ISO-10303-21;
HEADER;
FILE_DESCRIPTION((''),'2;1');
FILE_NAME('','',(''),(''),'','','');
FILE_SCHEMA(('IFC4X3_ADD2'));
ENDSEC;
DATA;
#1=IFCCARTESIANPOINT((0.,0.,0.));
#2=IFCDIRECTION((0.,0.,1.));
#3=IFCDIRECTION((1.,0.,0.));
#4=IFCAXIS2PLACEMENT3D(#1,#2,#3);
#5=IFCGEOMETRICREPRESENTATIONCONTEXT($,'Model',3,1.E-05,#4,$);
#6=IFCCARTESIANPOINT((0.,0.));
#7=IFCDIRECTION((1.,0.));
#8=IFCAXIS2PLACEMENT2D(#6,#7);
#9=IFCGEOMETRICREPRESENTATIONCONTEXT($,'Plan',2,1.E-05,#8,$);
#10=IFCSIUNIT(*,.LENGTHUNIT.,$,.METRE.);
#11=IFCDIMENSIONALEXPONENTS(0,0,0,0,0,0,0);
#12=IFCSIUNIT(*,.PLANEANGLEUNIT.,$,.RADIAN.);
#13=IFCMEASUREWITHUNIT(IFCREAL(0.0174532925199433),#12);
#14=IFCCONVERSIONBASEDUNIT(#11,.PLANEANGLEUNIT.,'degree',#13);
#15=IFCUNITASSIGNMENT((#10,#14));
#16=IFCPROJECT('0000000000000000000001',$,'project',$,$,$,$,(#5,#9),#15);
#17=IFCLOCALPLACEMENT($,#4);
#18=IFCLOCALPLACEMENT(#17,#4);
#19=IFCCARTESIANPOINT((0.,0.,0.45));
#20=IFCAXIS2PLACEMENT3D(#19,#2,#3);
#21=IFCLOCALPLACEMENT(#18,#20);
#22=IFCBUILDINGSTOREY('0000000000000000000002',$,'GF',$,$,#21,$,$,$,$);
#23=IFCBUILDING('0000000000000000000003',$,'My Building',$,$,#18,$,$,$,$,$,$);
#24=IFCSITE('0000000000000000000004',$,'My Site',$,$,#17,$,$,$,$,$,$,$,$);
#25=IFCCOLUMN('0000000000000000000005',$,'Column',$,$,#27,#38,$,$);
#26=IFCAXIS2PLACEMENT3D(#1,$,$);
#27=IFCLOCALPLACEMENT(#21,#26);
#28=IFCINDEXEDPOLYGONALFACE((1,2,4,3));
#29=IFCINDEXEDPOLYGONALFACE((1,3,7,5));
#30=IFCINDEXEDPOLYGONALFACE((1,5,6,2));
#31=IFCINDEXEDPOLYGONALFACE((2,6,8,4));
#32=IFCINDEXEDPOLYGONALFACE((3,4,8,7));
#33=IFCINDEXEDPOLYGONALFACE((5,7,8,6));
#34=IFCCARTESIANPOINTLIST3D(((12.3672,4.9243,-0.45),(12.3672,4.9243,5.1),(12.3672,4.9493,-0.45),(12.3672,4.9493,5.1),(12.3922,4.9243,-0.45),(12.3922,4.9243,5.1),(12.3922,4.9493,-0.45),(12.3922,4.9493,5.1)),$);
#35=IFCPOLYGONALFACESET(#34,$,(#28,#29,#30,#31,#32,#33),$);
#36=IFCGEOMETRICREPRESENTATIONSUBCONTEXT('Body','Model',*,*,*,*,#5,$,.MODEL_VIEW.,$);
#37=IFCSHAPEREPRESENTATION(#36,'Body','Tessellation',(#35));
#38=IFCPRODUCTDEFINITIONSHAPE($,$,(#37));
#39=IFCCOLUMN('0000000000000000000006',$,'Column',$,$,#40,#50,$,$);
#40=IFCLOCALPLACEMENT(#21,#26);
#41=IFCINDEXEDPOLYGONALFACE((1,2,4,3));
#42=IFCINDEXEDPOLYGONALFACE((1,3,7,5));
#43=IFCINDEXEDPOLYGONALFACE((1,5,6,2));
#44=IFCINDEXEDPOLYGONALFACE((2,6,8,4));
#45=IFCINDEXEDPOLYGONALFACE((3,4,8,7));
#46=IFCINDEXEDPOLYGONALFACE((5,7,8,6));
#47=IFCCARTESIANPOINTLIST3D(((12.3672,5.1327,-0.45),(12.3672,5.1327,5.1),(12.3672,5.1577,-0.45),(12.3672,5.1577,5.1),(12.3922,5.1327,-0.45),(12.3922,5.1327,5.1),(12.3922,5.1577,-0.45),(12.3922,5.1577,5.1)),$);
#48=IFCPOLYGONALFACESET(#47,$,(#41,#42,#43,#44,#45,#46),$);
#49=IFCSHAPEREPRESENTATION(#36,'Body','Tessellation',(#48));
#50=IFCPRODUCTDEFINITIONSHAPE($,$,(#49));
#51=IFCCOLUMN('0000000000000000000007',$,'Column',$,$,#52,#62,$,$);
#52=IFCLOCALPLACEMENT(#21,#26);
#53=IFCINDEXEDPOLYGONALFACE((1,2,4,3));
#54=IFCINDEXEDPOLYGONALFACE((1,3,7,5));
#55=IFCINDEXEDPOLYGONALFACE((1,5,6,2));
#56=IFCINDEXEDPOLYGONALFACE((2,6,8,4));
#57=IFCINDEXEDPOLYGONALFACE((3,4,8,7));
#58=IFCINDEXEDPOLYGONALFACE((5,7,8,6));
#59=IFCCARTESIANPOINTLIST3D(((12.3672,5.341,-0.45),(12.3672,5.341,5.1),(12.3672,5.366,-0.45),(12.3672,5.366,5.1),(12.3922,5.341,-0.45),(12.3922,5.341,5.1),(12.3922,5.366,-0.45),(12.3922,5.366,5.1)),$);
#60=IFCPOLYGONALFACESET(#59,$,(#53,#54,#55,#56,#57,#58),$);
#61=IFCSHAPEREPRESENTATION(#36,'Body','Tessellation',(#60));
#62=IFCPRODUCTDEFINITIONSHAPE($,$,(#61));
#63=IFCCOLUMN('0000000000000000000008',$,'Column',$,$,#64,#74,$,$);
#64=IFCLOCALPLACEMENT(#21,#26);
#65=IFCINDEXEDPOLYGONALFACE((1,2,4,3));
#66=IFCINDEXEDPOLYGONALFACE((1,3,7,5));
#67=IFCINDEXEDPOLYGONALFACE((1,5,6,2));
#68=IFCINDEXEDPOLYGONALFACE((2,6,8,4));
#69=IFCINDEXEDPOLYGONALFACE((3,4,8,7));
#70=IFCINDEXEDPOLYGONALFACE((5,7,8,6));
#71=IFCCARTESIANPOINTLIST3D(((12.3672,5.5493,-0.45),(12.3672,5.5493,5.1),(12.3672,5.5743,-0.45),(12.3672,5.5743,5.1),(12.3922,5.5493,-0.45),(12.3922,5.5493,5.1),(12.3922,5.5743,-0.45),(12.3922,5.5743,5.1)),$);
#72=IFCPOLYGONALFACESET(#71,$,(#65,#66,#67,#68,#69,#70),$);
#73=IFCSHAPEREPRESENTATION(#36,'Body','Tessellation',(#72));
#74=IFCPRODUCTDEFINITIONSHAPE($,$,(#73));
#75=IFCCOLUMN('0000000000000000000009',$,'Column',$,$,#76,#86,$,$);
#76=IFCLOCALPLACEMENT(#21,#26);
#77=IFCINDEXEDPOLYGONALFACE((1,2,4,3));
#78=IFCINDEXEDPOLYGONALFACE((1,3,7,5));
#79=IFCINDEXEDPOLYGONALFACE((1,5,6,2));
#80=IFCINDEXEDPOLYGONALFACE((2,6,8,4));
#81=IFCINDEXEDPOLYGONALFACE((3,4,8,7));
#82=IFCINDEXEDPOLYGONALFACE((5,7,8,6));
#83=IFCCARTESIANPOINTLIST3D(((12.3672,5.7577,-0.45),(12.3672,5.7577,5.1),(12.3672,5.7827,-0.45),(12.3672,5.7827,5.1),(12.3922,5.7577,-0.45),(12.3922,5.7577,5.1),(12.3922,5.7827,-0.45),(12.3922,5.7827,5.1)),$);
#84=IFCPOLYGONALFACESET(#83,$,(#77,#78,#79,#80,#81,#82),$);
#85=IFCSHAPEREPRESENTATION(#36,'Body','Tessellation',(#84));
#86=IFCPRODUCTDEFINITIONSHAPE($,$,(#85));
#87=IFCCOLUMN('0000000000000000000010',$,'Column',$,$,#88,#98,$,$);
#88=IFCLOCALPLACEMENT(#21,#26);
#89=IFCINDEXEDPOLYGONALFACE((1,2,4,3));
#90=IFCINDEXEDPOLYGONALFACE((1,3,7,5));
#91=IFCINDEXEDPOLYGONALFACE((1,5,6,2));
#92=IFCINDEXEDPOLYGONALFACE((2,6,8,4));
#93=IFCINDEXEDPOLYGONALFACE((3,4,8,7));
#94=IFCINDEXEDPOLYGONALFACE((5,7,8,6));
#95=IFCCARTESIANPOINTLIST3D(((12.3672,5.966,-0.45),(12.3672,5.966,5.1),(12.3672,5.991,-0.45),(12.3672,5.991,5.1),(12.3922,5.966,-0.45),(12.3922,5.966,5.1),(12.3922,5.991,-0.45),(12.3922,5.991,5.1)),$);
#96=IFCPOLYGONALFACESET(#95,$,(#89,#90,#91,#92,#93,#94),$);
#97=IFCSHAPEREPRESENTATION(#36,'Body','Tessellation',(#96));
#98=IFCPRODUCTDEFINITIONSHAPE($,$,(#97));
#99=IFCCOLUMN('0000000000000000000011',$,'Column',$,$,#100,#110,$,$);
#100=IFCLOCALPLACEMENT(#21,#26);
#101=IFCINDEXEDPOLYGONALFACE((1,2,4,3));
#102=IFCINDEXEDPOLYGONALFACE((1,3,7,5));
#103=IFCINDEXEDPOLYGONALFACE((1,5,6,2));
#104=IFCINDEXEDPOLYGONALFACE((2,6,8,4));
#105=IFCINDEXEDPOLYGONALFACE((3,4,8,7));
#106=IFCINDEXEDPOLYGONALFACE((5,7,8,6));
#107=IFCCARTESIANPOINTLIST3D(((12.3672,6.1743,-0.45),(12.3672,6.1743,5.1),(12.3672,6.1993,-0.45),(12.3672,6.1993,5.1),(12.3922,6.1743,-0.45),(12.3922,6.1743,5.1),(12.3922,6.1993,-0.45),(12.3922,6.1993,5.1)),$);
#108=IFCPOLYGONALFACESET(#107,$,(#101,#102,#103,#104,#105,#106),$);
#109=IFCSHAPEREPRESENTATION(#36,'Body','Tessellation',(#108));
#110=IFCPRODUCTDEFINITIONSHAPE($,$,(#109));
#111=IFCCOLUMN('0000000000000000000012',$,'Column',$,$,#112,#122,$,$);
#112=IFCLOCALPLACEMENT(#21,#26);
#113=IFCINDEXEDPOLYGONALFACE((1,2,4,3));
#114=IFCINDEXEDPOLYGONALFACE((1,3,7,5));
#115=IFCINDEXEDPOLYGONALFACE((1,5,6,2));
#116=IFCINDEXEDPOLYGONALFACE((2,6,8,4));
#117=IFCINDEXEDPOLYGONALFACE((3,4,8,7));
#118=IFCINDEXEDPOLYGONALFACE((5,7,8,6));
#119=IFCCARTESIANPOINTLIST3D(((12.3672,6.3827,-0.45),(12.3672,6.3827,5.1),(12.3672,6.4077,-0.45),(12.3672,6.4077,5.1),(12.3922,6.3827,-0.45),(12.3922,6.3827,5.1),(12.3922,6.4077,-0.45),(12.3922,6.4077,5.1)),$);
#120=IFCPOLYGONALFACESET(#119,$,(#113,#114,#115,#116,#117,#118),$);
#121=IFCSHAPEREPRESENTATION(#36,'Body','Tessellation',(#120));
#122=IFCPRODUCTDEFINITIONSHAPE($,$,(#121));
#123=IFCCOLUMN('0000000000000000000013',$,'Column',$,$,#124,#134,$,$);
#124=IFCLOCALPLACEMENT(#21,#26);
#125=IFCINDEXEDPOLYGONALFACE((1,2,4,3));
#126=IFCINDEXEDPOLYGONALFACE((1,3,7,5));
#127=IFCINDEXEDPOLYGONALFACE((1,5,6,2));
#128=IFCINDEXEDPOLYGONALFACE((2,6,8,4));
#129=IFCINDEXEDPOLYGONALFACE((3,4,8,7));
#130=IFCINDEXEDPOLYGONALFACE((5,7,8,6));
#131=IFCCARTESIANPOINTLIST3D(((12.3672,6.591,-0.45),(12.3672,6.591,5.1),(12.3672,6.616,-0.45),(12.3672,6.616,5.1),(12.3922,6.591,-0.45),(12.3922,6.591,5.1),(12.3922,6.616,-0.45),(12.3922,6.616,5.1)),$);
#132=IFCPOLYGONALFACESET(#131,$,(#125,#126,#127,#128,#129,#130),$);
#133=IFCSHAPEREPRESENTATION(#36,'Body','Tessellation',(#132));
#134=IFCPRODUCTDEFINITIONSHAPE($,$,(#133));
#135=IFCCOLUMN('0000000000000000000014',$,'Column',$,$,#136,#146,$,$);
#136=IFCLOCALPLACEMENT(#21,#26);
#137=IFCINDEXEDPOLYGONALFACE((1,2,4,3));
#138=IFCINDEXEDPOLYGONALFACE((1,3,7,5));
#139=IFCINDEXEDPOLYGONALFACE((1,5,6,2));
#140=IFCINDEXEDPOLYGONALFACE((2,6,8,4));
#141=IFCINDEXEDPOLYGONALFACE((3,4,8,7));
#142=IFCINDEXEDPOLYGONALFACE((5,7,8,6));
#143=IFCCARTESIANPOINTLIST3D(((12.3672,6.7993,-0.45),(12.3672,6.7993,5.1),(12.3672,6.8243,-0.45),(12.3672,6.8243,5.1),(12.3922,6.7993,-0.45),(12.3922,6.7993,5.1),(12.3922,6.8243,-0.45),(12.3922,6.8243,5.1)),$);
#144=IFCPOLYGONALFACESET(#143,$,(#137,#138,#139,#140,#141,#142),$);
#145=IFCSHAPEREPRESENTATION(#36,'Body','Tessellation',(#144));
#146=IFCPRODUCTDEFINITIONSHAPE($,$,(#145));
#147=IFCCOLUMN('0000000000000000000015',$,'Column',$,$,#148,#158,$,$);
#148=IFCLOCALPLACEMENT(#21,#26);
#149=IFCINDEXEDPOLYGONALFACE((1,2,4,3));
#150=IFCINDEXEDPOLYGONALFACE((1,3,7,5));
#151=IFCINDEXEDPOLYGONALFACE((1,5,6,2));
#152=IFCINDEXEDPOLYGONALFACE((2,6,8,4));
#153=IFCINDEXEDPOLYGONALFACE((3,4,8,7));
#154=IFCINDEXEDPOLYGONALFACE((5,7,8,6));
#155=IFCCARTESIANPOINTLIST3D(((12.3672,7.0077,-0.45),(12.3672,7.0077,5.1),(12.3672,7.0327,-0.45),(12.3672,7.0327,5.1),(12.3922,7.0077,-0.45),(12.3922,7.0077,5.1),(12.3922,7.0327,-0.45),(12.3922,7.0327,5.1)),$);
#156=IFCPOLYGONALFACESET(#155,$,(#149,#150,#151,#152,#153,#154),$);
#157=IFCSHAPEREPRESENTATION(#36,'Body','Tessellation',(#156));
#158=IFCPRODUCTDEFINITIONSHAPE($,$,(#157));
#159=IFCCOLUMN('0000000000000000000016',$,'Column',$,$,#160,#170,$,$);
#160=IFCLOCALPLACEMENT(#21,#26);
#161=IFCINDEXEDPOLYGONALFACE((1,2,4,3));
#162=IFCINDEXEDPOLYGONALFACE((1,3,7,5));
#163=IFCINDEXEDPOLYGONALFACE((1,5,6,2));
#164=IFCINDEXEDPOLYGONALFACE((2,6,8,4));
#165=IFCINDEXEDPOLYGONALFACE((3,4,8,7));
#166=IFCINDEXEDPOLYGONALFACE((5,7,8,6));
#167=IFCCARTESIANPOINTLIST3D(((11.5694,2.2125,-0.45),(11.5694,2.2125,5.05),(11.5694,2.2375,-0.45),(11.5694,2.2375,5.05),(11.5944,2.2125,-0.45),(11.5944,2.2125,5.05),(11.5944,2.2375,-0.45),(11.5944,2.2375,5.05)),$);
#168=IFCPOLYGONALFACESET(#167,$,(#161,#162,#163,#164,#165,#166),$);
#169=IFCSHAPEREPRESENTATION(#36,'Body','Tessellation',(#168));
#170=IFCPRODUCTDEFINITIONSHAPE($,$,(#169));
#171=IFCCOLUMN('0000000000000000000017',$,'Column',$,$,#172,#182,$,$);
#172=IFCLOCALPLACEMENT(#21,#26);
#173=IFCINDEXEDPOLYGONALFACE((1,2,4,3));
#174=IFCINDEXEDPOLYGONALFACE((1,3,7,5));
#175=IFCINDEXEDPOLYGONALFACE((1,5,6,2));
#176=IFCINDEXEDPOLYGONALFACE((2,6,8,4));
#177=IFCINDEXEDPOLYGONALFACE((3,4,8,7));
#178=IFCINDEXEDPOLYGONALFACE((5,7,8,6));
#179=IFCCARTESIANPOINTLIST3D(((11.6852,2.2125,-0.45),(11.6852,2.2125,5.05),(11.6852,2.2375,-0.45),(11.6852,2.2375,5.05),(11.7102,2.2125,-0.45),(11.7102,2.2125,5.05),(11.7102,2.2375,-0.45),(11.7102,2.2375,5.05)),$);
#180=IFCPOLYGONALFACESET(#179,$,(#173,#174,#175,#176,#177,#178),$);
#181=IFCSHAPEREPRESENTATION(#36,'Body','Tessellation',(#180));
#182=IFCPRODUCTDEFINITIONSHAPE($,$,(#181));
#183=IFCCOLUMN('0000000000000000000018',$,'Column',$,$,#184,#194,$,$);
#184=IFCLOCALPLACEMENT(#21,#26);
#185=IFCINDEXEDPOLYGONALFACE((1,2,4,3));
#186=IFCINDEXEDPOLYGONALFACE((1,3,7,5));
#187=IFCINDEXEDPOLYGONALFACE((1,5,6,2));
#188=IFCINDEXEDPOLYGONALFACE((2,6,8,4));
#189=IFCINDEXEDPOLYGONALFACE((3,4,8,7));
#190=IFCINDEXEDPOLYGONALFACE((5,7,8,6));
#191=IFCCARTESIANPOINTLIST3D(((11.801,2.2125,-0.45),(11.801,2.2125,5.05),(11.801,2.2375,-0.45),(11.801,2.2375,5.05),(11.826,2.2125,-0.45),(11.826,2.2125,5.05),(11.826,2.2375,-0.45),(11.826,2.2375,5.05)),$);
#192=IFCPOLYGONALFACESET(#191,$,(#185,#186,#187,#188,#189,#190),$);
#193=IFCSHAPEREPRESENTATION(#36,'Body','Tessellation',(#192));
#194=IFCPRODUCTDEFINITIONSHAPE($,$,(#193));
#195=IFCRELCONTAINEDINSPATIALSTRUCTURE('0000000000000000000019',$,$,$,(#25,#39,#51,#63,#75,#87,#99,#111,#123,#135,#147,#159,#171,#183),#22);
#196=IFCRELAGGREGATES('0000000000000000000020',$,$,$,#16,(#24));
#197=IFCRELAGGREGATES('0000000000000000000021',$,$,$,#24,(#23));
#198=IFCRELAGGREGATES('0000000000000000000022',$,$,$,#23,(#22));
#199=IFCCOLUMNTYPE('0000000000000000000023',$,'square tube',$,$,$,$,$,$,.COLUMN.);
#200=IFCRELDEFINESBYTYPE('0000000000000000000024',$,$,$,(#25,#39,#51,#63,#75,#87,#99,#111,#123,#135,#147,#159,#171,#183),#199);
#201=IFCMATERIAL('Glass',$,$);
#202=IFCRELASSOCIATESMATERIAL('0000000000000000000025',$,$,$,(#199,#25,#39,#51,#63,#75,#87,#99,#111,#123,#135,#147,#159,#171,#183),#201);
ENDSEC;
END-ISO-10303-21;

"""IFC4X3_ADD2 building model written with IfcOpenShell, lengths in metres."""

from ifc_helpers import new_model, entity, si_unit, converted_unit, frame, origin_with_axes, origin_2d_with_axis, place, context, subcontext, project, spatial, rectangle, extrude, material, material_profile, profile_set, profile_usage, type_object, element, save


model = new_model("IFC4X3_ADD2")

# Units and contexts
model_context = context("Model", 3, precision=1e-05, world=origin_with_axes())
plan_context = context("Plan", 2, precision=1e-05, world=origin_2d_with_axis())
body_context = subcontext(model_context, "Body", "Model", "MODEL_VIEW")
ifc_project = project(units=[si_unit("LENGTHUNIT", "METRE"), converted_unit("PLANEANGLEUNIT", "degree", entity("IfcReal", 0.0174532925199433), si_unit("PLANEANGLEUNIT", "RADIAN"), dimensions=[0, 0, 0, 0, 0, 0, 0])], contexts=[model_context, plan_context])

# Site, building, storey
site_placement = place(None, origin_with_axes())
site = spatial("IfcSite", under=ifc_project, at=site_placement, Name="My Site")
building_placement = place(site_placement, origin_with_axes())
building = spatial("IfcBuilding", under=site, at=building_placement, Name="My Building")
storey_placement = place(building_placement, frame((0.0, 0.0, 0.45), z_axis=(0.0, 0.0, 1.0), x_axis=(1.0, 0.0, 0.0)))
storey = spatial("IfcBuildingStorey", under=building, at=storey_placement, Name="GF")

# Columns
ifc_material_1 = material(Name="Glass")
ifc_material_profile = material_profile(ifc_material_1, rectangle(XDim=0.025, YDim=0.025))
ifc_profile_set = profile_set([ifc_material_profile])
column_type = type_object("IfcColumnType", Name="square tube", PredefinedType="COLUMN", material=ifc_profile_set)
ifc_profile_usage_1 = profile_usage(ifc_profile_set, cardinal=5)
column_1_placement = place(storey_placement, frame((12.3797, 4.9368, -0.45), z_axis=(0.0, 0.0, 1.0), x_axis=(0.0, 1.0, 0.0)))
element("IfcColumn", 1, at=column_1_placement, inside=storey, type_object=column_type, material=ifc_profile_usage_1, Name="Column", context=body_context, shape_type="SweptSolid", body=[
    extrude(rectangle(XDim=0.025, YDim=0.025), origin_with_axes(), (0.0, 0.0, 1.0), 5.55),
])
ifc_profile_usage_2 = profile_usage(ifc_profile_set, cardinal=5)
column_2_placement = place(storey_placement, frame((12.3797, 5.1452, -0.45), z_axis=(0.0, 0.0, 1.0), x_axis=(0.0, 1.0, 0.0)))
element("IfcColumn", 2, at=column_2_placement, inside=storey, type_object=column_type, material=ifc_profile_usage_2, Name="Column", context=body_context, shape_type="SweptSolid", body=[
    extrude(rectangle(XDim=0.025, YDim=0.025), origin_with_axes(), (0.0, 0.0, 1.0), 5.55),
])
ifc_profile_usage_3 = profile_usage(ifc_profile_set, cardinal=5)
column_3_placement = place(storey_placement, frame((12.3797, 5.3535, -0.45), z_axis=(0.0, 0.0, 1.0), x_axis=(0.0, 1.0, 0.0)))
element("IfcColumn", 3, at=column_3_placement, inside=storey, type_object=column_type, material=ifc_profile_usage_3, Name="Column", context=body_context, shape_type="SweptSolid", body=[
    extrude(rectangle(XDim=0.025, YDim=0.025), origin_with_axes(), (0.0, 0.0, 1.0), 5.55),
])
ifc_profile_usage_4 = profile_usage(ifc_profile_set, cardinal=5)
column_4_placement = place(storey_placement, frame((12.3797, 5.5618, -0.45), z_axis=(0.0, 0.0, 1.0), x_axis=(0.0, 1.0, 0.0)))
element("IfcColumn", 4, at=column_4_placement, inside=storey, type_object=column_type, material=ifc_profile_usage_4, Name="Column", context=body_context, shape_type="SweptSolid", body=[
    extrude(rectangle(XDim=0.025, YDim=0.025), origin_with_axes(), (0.0, 0.0, 1.0), 5.55),
])
ifc_profile_usage_5 = profile_usage(ifc_profile_set, cardinal=5)
column_5_placement = place(storey_placement, frame((12.3797, 5.7702, -0.45), z_axis=(0.0, 0.0, 1.0), x_axis=(0.0, 1.0, 0.0)))
element("IfcColumn", 5, at=column_5_placement, inside=storey, type_object=column_type, material=ifc_profile_usage_5, Name="Column", context=body_context, shape_type="SweptSolid", body=[
    extrude(rectangle(XDim=0.025, YDim=0.025), origin_with_axes(), (0.0, 0.0, 1.0), 5.55),
])
ifc_profile_usage_6 = profile_usage(ifc_profile_set, cardinal=5)
column_6_placement = place(storey_placement, frame((12.3797, 5.9785, -0.45), z_axis=(0.0, 0.0, 1.0), x_axis=(0.0, 1.0, 0.0)))
element("IfcColumn", 6, at=column_6_placement, inside=storey, type_object=column_type, material=ifc_profile_usage_6, Name="Column", context=body_context, shape_type="SweptSolid", body=[
    extrude(rectangle(XDim=0.025, YDim=0.025), origin_with_axes(), (0.0, 0.0, 1.0), 5.55),
])
ifc_profile_usage_7 = profile_usage(ifc_profile_set, cardinal=5)
column_7_placement = place(storey_placement, frame((12.3797, 6.1868, -0.45), z_axis=(0.0, 0.0, 1.0), x_axis=(0.0, 1.0, 0.0)))
element("IfcColumn", 7, at=column_7_placement, inside=storey, type_object=column_type, material=ifc_profile_usage_7, Name="Column", context=body_context, shape_type="SweptSolid", body=[
    extrude(rectangle(XDim=0.025, YDim=0.025), origin_with_axes(), (0.0, 0.0, 1.0), 5.55),
])
ifc_profile_usage_8 = profile_usage(ifc_profile_set, cardinal=5)
column_8_placement = place(storey_placement, frame((12.3797, 6.3952, -0.45), z_axis=(0.0, 0.0, 1.0), x_axis=(0.0, 1.0, 0.0)))
element("IfcColumn", 8, at=column_8_placement, inside=storey, type_object=column_type, material=ifc_profile_usage_8, Name="Column", context=body_context, shape_type="SweptSolid", body=[
    extrude(rectangle(XDim=0.025, YDim=0.025), origin_with_axes(), (0.0, 0.0, 1.0), 5.55),
])
ifc_profile_usage_9 = profile_usage(ifc_profile_set, cardinal=5)
column_9_placement = place(storey_placement, frame((12.3797, 6.6035, -0.45), z_axis=(0.0, 0.0, 1.0), x_axis=(0.0, 1.0, 0.0)))
element("IfcColumn", 9, at=column_9_placement, inside=storey, type_object=column_type, material=ifc_profile_usage_9, Name="Column", context=body_context, shape_type="SweptSolid", body=[
    extrude(rectangle(XDim=0.025, YDim=0.025), origin_with_axes(), (0.0, 0.0, 1.0), 5.55),
])
ifc_profile_usage_10 = profile_usage(ifc_profile_set, cardinal=5)
column_10_placement = place(storey_placement, frame((12.3797, 6.8118, -0.45), z_axis=(0.0, 0.0, 1.0), x_axis=(0.0, 1.0, 0.0)))
element("IfcColumn", 10, at=column_10_placement, inside=storey, type_object=column_type, material=ifc_profile_usage_10, Name="Column", context=body_context, shape_type="SweptSolid", body=[
    extrude(rectangle(XDim=0.025, YDim=0.025), origin_with_axes(), (0.0, 0.0, 1.0), 5.55),
])
ifc_profile_usage_11 = profile_usage(ifc_profile_set, cardinal=5)
column_11_placement = place(storey_placement, frame((12.3797, 7.0202, -0.45), z_axis=(0.0, 0.0, 1.0), x_axis=(0.0, 1.0, 0.0)))
element("IfcColumn", 11, at=column_11_placement, inside=storey, type_object=column_type, material=ifc_profile_usage_11, Name="Column", context=body_context, shape_type="SweptSolid", body=[
    extrude(rectangle(XDim=0.025, YDim=0.025), origin_with_axes(), (0.0, 0.0, 1.0), 5.55),
])
ifc_profile_usage_12 = profile_usage(ifc_profile_set, cardinal=5)
column_12_placement = place(storey_placement, frame((11.5819, 2.225, -0.45), z_axis=(0.0, 0.0, 1.0), x_axis=(1.0, 0.0, 0.0)))
element("IfcColumn", 12, at=column_12_placement, inside=storey, type_object=column_type, material=ifc_profile_usage_12, Name="Column", context=body_context, shape_type="SweptSolid", body=[
    extrude(rectangle(XDim=0.025, YDim=0.025), origin_with_axes(), (0.0, 0.0, 1.0), 5.5),
])
ifc_profile_usage_13 = profile_usage(ifc_profile_set, cardinal=5)
column_13_placement = place(storey_placement, frame((11.6977, 2.225, -0.45), z_axis=(0.0, 0.0, 1.0), x_axis=(1.0, 0.0, 0.0)))
element("IfcColumn", 13, at=column_13_placement, inside=storey, type_object=column_type, material=ifc_profile_usage_13, Name="Column", context=body_context, shape_type="SweptSolid", body=[
    extrude(rectangle(XDim=0.025, YDim=0.025), origin_with_axes(), (0.0, 0.0, 1.0), 5.5),
])
ifc_profile_usage_14 = profile_usage(ifc_profile_set, cardinal=5)
column_14_placement = place(storey_placement, frame((11.8135, 2.225, -0.45), z_axis=(0.0, 0.0, 1.0), x_axis=(1.0, 0.0, 0.0)))
element("IfcColumn", 14, at=column_14_placement, inside=storey, type_object=column_type, material=ifc_profile_usage_14, Name="Column", context=body_context, shape_type="SweptSolid", body=[
    extrude(rectangle(XDim=0.025, YDim=0.025), origin_with_axes(), (0.0, 0.0, 1.0), 5.5),
])

save(model, "model.ifc")
